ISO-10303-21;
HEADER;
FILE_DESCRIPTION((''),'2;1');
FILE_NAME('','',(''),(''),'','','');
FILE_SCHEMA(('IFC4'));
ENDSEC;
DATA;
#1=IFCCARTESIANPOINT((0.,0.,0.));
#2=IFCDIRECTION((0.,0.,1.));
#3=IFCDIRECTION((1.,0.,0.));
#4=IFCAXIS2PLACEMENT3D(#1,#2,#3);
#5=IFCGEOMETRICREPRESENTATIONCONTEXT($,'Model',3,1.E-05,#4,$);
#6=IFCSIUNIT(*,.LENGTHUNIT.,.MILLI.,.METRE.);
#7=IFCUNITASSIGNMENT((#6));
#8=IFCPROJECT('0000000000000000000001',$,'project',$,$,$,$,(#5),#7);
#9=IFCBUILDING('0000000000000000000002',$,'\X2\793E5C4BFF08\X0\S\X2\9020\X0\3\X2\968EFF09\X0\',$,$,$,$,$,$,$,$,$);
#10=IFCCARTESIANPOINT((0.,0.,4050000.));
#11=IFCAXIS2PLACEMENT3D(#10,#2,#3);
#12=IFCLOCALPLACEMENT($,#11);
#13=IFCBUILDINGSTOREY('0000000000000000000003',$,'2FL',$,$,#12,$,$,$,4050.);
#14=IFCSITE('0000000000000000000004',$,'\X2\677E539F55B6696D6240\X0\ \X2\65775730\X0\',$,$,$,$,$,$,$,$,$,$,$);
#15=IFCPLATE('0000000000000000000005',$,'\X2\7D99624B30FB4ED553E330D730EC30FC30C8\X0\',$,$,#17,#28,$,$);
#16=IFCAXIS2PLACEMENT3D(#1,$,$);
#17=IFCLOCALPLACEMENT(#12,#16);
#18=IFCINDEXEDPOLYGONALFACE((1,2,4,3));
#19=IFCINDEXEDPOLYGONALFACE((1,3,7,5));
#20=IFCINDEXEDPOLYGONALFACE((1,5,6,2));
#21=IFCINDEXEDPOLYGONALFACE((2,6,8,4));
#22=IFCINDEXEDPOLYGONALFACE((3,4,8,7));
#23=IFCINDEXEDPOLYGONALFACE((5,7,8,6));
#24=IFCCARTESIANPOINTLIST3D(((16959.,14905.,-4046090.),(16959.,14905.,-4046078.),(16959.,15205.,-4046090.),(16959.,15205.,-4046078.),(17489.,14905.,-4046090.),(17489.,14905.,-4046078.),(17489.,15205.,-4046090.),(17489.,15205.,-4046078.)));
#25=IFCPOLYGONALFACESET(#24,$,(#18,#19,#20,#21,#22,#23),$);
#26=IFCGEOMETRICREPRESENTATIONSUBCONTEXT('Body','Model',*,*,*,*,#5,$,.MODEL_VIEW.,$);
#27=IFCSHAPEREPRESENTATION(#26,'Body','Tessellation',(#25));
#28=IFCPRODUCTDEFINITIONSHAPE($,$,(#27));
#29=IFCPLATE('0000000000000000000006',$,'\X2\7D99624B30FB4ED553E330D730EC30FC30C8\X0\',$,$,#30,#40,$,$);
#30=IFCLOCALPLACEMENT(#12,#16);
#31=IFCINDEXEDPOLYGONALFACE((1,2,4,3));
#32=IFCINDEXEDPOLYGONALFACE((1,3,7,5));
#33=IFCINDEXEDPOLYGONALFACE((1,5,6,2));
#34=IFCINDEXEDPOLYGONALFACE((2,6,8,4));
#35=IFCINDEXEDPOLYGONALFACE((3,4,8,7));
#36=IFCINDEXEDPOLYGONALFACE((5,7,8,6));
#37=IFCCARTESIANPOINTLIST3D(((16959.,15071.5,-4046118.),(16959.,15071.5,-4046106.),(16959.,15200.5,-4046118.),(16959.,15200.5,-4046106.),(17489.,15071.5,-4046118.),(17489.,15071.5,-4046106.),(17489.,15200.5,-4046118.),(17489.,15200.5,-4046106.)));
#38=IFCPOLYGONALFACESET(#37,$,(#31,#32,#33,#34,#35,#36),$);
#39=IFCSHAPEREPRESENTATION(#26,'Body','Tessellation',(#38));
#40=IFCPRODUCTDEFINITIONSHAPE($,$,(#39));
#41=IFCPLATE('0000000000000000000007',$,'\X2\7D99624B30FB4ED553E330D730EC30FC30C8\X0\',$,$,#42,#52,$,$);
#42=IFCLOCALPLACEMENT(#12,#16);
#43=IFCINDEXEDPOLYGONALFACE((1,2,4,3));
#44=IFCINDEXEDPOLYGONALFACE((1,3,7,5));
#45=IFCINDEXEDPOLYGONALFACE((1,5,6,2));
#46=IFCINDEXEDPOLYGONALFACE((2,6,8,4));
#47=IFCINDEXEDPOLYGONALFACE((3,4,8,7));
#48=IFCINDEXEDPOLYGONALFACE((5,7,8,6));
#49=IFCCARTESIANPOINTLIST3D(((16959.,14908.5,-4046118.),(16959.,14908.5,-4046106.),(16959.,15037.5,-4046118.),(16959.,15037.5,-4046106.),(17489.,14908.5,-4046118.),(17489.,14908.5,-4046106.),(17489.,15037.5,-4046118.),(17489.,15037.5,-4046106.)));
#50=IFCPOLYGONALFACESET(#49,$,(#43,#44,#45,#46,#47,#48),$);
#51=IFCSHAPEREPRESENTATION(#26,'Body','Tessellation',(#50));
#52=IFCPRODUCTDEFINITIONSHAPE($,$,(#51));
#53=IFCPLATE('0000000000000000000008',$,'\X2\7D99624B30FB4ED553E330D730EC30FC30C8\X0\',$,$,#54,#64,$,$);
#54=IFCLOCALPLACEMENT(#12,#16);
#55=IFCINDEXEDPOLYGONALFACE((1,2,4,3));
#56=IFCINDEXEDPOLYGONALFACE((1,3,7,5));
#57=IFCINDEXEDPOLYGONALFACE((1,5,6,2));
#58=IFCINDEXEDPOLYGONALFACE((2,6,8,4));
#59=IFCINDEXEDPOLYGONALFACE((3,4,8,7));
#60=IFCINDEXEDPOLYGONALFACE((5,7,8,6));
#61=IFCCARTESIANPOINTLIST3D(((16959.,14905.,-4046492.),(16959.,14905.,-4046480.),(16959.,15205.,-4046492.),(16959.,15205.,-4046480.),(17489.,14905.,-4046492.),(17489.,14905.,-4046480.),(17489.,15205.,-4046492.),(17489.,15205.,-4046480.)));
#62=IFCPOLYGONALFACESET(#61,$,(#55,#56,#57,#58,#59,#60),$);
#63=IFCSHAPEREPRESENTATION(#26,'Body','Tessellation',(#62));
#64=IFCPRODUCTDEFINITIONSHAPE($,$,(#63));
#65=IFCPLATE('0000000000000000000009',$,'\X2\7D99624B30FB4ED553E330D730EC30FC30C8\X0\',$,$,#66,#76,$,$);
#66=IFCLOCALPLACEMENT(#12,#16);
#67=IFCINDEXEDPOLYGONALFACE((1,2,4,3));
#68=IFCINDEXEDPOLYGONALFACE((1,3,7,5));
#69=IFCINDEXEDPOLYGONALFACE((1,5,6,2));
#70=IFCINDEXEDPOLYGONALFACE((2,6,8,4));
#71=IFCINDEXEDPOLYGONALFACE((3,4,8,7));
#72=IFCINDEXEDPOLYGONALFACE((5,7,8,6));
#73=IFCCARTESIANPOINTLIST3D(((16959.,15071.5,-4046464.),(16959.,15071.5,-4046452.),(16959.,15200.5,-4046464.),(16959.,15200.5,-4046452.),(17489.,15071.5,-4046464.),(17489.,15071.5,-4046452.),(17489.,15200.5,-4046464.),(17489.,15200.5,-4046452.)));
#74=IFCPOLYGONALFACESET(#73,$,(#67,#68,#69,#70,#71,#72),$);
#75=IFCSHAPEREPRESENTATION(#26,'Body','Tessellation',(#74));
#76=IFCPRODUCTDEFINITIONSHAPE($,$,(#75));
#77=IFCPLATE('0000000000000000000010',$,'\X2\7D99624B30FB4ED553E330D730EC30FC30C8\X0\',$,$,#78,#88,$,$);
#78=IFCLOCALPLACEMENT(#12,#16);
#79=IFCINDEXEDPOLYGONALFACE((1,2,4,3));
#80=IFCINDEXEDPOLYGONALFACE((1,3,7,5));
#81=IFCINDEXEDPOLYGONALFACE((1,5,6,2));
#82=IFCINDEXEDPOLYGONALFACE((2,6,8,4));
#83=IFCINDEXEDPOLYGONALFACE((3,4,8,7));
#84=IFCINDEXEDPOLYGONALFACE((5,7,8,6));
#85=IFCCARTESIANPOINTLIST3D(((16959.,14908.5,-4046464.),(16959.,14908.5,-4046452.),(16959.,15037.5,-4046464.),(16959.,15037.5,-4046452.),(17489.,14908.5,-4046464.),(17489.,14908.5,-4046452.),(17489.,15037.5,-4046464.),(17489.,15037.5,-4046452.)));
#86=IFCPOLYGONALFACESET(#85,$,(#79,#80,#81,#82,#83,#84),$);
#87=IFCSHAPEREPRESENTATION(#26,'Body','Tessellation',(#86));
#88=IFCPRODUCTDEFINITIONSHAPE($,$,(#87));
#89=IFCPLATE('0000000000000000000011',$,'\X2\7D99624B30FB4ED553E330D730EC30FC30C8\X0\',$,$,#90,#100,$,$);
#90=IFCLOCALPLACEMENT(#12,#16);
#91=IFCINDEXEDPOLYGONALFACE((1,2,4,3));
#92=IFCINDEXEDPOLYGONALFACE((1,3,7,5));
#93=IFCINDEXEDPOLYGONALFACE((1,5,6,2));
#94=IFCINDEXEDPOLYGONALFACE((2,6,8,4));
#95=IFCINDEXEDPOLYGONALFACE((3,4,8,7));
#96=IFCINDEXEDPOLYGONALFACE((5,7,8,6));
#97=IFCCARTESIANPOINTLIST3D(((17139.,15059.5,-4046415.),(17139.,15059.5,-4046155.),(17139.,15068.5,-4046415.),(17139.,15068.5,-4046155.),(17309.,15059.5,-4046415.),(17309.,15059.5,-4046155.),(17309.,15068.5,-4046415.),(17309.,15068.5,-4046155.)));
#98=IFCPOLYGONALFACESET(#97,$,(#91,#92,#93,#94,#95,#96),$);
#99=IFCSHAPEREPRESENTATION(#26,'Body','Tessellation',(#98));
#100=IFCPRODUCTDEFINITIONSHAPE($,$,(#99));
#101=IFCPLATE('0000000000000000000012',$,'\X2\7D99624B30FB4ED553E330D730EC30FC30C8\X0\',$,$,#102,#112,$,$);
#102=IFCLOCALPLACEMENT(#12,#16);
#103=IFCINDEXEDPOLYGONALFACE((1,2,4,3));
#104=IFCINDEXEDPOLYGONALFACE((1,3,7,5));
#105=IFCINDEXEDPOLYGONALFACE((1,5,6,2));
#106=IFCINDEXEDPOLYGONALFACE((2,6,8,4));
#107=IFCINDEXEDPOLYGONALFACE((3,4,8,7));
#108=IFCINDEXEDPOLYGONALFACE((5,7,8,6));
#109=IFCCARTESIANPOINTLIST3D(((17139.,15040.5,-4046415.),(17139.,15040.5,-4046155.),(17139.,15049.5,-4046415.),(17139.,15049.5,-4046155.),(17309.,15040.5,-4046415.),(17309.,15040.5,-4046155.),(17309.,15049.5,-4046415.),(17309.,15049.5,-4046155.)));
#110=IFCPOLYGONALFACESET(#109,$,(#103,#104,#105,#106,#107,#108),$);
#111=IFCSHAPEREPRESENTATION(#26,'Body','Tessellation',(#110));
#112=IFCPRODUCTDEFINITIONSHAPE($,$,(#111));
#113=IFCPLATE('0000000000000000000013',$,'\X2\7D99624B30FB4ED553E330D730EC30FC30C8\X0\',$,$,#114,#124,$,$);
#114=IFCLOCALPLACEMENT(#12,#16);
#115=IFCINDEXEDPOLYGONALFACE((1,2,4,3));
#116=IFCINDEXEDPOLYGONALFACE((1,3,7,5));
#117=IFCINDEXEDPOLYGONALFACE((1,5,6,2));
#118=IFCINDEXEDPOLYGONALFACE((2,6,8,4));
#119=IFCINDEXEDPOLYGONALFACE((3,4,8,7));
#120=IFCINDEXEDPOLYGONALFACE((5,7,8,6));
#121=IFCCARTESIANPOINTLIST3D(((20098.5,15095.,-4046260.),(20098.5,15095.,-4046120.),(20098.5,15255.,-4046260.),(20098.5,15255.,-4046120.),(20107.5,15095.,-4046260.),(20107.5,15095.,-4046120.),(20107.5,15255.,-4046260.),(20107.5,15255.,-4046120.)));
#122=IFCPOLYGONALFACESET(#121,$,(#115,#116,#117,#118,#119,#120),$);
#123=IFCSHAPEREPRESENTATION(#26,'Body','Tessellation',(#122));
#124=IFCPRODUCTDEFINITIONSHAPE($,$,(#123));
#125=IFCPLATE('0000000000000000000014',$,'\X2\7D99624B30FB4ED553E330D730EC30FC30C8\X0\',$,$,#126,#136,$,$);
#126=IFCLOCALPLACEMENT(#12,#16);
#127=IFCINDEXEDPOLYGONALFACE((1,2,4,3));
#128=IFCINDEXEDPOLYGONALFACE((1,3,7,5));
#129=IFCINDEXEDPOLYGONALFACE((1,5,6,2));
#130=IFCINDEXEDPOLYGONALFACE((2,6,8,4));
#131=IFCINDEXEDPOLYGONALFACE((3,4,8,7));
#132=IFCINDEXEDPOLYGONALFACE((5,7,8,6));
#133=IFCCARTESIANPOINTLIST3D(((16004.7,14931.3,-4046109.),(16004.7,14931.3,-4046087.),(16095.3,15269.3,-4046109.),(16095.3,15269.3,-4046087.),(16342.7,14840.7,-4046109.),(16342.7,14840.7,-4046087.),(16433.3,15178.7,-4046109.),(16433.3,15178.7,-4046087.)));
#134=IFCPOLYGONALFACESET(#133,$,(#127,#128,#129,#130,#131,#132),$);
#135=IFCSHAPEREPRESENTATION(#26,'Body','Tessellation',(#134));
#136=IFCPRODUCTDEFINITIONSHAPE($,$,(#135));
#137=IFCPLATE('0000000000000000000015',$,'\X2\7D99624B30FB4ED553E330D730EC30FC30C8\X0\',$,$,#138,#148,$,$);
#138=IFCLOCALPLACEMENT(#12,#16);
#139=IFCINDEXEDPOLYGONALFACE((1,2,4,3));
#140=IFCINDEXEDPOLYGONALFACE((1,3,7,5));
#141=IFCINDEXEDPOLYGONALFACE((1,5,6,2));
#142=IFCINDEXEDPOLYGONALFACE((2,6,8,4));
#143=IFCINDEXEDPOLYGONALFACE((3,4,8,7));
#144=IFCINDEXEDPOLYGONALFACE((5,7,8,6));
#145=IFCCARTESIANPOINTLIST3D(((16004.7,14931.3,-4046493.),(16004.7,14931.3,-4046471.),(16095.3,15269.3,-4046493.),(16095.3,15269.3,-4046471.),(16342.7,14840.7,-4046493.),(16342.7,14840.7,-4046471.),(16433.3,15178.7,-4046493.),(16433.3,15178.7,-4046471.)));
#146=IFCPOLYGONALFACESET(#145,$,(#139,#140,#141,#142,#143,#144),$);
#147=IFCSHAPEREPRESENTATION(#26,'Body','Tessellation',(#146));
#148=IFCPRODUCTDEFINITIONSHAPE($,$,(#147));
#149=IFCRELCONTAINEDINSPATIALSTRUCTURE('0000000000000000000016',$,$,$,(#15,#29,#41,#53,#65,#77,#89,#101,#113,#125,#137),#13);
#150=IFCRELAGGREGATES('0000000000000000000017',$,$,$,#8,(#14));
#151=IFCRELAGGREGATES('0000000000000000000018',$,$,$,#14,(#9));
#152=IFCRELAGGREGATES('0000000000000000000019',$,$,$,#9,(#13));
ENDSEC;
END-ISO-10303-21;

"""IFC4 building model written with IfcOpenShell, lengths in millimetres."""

from ifc_helpers import new_model, si_unit, frame, origin, origin_with_axes, place, context, subcontext, project, spatial, rectangle, extrude, element, save


model = new_model("IFC4")

# Units and contexts
model_context = context("Model", 3, precision=1e-05, world=origin_with_axes())
body_context = subcontext(model_context, "Body", "Model", "MODEL_VIEW")
ifc_project = project(units=[si_unit("LENGTHUNIT", "METRE", prefix="MILLI")], contexts=[model_context])

# Site, building, storey
site = spatial("IfcSite", under=ifc_project, Name="松原営業所 敷地")
building = spatial("IfcBuilding", under=site, Name="社屋（S造3階）")
storey_placement = place(None, frame((0.0, 0.0, 4050000.0), z_axis=(0.0, 0.0, 1.0), x_axis=(1.0, 0.0, 0.0)))
storey = spatial("IfcBuildingStorey", under=building, at=storey_placement, Name="2FL", Elevation=4050.0)

# Plates
plate_1_placement = place(storey_placement, frame((16959.0, 15055.0, -4046084.0), z_axis=(1.0, 0.0, 0.0), x_axis=(0.0, 1.0, 0.0)))
element("IfcPlate", 1, at=plate_1_placement, inside=storey, Name="継手・仕口プレート", context=body_context, shape_type="SweptSolid", body=[
    extrude(rectangle(XDim=300.0, YDim=12.0), origin(), (0.0, 0.0, 1.0), 530.0),
])
for number, where, z_axis, x_axis, name in (
    (2, (16959.0, 15136.0, -4046112.0), (1.0, 0.0, 0.0), (0.0, 1.0, 0.0), "継手・仕口プレート"),
    (3, (16959.0, 14973.0, -4046112.0), (1.0, 0.0, 0.0), (0.0, 1.0, 0.0), "継手・仕口プレート"),
):
    element("IfcPlate", number, at=place(storey_placement, frame(where, z_axis=z_axis, x_axis=x_axis)), inside=storey, Name=name, context=body_context, shape_type="SweptSolid", body=[
        extrude(rectangle(XDim=129.0, YDim=12.0), origin(), (0.0, 0.0, 1.0), 530.0),
    ])
plate_2_placement = place(storey_placement, frame((16959.0, 15055.0, -4046486.0), z_axis=(1.0, 0.0, 0.0), x_axis=(0.0, 1.0, 0.0)))
element("IfcPlate", 4, at=plate_2_placement, inside=storey, Name="継手・仕口プレート", context=body_context, shape_type="SweptSolid", body=[
    extrude(rectangle(XDim=300.0, YDim=12.0), origin(), (0.0, 0.0, 1.0), 530.0),
])
for number, where, z_axis, x_axis, name in (
    (5, (16959.0, 15136.0, -4046458.0), (1.0, 0.0, 0.0), (0.0, 1.0, 0.0), "継手・仕口プレート"),
    (6, (16959.0, 14973.0, -4046458.0), (1.0, 0.0, 0.0), (0.0, 1.0, 0.0), "継手・仕口プレート"),
):
    element("IfcPlate", number, at=place(storey_placement, frame(where, z_axis=z_axis, x_axis=x_axis)), inside=storey, Name=name, context=body_context, shape_type="SweptSolid", body=[
        extrude(rectangle(XDim=129.0, YDim=12.0), origin(), (0.0, 0.0, 1.0), 530.0),
    ])
for number, where, z_axis, x_axis, name in (
    (7, (17139.0, 15064.0, -4046285.0), (1.0, 0.0, 0.0), (0.0, 1.0, 0.0), "継手・仕口プレート"),
    (8, (17139.0, 15045.0, -4046285.0), (1.0, 0.0, 0.0), (0.0, 1.0, 0.0), "継手・仕口プレート"),
):
    element("IfcPlate", number, at=place(storey_placement, frame(where, z_axis=z_axis, x_axis=x_axis)), inside=storey, Name=name, context=body_context, shape_type="SweptSolid", body=[
        extrude(rectangle(XDim=9.0, YDim=260.0), origin(), (0.0, 0.0, 1.0), 170.0),
    ])
plate_3_placement = place(storey_placement, frame((20103.0, 15095.0, -4046190.0), z_axis=(0.0, 1.0, 0.0), x_axis=(-1.0, 0.0, 0.0)))
element("IfcPlate", 9, at=plate_3_placement, inside=storey, Name="継手・仕口プレート", context=body_context, shape_type="SweptSolid", body=[
    extrude(rectangle(XDim=9.0, YDim=140.0), origin(), (0.0, 0.0, 1.0), 160.0),
])
for number, where, z_axis, x_axis, name in (
    (10, (16050.0, 15100.3, -4046098.0), (0.965926, -0.258819, 0.0), (0.258819, 0.965926, 0.0), "継手・仕口プレート"),
    (11, (16050.0, 15100.3, -4046482.0), (0.965926, -0.258819, 0.0), (0.258819, 0.965926, 0.0), "継手・仕口プレート"),
):
    element("IfcPlate", number, at=place(storey_placement, frame(where, z_axis=z_axis, x_axis=x_axis)), inside=storey, Name=name, context=body_context, shape_type="SweptSolid", body=[
        extrude(rectangle(XDim=350.0, YDim=22.0), origin(), (0.0, 0.0, 1.0), 350.0),
    ])

save(model, "model.ifc")
